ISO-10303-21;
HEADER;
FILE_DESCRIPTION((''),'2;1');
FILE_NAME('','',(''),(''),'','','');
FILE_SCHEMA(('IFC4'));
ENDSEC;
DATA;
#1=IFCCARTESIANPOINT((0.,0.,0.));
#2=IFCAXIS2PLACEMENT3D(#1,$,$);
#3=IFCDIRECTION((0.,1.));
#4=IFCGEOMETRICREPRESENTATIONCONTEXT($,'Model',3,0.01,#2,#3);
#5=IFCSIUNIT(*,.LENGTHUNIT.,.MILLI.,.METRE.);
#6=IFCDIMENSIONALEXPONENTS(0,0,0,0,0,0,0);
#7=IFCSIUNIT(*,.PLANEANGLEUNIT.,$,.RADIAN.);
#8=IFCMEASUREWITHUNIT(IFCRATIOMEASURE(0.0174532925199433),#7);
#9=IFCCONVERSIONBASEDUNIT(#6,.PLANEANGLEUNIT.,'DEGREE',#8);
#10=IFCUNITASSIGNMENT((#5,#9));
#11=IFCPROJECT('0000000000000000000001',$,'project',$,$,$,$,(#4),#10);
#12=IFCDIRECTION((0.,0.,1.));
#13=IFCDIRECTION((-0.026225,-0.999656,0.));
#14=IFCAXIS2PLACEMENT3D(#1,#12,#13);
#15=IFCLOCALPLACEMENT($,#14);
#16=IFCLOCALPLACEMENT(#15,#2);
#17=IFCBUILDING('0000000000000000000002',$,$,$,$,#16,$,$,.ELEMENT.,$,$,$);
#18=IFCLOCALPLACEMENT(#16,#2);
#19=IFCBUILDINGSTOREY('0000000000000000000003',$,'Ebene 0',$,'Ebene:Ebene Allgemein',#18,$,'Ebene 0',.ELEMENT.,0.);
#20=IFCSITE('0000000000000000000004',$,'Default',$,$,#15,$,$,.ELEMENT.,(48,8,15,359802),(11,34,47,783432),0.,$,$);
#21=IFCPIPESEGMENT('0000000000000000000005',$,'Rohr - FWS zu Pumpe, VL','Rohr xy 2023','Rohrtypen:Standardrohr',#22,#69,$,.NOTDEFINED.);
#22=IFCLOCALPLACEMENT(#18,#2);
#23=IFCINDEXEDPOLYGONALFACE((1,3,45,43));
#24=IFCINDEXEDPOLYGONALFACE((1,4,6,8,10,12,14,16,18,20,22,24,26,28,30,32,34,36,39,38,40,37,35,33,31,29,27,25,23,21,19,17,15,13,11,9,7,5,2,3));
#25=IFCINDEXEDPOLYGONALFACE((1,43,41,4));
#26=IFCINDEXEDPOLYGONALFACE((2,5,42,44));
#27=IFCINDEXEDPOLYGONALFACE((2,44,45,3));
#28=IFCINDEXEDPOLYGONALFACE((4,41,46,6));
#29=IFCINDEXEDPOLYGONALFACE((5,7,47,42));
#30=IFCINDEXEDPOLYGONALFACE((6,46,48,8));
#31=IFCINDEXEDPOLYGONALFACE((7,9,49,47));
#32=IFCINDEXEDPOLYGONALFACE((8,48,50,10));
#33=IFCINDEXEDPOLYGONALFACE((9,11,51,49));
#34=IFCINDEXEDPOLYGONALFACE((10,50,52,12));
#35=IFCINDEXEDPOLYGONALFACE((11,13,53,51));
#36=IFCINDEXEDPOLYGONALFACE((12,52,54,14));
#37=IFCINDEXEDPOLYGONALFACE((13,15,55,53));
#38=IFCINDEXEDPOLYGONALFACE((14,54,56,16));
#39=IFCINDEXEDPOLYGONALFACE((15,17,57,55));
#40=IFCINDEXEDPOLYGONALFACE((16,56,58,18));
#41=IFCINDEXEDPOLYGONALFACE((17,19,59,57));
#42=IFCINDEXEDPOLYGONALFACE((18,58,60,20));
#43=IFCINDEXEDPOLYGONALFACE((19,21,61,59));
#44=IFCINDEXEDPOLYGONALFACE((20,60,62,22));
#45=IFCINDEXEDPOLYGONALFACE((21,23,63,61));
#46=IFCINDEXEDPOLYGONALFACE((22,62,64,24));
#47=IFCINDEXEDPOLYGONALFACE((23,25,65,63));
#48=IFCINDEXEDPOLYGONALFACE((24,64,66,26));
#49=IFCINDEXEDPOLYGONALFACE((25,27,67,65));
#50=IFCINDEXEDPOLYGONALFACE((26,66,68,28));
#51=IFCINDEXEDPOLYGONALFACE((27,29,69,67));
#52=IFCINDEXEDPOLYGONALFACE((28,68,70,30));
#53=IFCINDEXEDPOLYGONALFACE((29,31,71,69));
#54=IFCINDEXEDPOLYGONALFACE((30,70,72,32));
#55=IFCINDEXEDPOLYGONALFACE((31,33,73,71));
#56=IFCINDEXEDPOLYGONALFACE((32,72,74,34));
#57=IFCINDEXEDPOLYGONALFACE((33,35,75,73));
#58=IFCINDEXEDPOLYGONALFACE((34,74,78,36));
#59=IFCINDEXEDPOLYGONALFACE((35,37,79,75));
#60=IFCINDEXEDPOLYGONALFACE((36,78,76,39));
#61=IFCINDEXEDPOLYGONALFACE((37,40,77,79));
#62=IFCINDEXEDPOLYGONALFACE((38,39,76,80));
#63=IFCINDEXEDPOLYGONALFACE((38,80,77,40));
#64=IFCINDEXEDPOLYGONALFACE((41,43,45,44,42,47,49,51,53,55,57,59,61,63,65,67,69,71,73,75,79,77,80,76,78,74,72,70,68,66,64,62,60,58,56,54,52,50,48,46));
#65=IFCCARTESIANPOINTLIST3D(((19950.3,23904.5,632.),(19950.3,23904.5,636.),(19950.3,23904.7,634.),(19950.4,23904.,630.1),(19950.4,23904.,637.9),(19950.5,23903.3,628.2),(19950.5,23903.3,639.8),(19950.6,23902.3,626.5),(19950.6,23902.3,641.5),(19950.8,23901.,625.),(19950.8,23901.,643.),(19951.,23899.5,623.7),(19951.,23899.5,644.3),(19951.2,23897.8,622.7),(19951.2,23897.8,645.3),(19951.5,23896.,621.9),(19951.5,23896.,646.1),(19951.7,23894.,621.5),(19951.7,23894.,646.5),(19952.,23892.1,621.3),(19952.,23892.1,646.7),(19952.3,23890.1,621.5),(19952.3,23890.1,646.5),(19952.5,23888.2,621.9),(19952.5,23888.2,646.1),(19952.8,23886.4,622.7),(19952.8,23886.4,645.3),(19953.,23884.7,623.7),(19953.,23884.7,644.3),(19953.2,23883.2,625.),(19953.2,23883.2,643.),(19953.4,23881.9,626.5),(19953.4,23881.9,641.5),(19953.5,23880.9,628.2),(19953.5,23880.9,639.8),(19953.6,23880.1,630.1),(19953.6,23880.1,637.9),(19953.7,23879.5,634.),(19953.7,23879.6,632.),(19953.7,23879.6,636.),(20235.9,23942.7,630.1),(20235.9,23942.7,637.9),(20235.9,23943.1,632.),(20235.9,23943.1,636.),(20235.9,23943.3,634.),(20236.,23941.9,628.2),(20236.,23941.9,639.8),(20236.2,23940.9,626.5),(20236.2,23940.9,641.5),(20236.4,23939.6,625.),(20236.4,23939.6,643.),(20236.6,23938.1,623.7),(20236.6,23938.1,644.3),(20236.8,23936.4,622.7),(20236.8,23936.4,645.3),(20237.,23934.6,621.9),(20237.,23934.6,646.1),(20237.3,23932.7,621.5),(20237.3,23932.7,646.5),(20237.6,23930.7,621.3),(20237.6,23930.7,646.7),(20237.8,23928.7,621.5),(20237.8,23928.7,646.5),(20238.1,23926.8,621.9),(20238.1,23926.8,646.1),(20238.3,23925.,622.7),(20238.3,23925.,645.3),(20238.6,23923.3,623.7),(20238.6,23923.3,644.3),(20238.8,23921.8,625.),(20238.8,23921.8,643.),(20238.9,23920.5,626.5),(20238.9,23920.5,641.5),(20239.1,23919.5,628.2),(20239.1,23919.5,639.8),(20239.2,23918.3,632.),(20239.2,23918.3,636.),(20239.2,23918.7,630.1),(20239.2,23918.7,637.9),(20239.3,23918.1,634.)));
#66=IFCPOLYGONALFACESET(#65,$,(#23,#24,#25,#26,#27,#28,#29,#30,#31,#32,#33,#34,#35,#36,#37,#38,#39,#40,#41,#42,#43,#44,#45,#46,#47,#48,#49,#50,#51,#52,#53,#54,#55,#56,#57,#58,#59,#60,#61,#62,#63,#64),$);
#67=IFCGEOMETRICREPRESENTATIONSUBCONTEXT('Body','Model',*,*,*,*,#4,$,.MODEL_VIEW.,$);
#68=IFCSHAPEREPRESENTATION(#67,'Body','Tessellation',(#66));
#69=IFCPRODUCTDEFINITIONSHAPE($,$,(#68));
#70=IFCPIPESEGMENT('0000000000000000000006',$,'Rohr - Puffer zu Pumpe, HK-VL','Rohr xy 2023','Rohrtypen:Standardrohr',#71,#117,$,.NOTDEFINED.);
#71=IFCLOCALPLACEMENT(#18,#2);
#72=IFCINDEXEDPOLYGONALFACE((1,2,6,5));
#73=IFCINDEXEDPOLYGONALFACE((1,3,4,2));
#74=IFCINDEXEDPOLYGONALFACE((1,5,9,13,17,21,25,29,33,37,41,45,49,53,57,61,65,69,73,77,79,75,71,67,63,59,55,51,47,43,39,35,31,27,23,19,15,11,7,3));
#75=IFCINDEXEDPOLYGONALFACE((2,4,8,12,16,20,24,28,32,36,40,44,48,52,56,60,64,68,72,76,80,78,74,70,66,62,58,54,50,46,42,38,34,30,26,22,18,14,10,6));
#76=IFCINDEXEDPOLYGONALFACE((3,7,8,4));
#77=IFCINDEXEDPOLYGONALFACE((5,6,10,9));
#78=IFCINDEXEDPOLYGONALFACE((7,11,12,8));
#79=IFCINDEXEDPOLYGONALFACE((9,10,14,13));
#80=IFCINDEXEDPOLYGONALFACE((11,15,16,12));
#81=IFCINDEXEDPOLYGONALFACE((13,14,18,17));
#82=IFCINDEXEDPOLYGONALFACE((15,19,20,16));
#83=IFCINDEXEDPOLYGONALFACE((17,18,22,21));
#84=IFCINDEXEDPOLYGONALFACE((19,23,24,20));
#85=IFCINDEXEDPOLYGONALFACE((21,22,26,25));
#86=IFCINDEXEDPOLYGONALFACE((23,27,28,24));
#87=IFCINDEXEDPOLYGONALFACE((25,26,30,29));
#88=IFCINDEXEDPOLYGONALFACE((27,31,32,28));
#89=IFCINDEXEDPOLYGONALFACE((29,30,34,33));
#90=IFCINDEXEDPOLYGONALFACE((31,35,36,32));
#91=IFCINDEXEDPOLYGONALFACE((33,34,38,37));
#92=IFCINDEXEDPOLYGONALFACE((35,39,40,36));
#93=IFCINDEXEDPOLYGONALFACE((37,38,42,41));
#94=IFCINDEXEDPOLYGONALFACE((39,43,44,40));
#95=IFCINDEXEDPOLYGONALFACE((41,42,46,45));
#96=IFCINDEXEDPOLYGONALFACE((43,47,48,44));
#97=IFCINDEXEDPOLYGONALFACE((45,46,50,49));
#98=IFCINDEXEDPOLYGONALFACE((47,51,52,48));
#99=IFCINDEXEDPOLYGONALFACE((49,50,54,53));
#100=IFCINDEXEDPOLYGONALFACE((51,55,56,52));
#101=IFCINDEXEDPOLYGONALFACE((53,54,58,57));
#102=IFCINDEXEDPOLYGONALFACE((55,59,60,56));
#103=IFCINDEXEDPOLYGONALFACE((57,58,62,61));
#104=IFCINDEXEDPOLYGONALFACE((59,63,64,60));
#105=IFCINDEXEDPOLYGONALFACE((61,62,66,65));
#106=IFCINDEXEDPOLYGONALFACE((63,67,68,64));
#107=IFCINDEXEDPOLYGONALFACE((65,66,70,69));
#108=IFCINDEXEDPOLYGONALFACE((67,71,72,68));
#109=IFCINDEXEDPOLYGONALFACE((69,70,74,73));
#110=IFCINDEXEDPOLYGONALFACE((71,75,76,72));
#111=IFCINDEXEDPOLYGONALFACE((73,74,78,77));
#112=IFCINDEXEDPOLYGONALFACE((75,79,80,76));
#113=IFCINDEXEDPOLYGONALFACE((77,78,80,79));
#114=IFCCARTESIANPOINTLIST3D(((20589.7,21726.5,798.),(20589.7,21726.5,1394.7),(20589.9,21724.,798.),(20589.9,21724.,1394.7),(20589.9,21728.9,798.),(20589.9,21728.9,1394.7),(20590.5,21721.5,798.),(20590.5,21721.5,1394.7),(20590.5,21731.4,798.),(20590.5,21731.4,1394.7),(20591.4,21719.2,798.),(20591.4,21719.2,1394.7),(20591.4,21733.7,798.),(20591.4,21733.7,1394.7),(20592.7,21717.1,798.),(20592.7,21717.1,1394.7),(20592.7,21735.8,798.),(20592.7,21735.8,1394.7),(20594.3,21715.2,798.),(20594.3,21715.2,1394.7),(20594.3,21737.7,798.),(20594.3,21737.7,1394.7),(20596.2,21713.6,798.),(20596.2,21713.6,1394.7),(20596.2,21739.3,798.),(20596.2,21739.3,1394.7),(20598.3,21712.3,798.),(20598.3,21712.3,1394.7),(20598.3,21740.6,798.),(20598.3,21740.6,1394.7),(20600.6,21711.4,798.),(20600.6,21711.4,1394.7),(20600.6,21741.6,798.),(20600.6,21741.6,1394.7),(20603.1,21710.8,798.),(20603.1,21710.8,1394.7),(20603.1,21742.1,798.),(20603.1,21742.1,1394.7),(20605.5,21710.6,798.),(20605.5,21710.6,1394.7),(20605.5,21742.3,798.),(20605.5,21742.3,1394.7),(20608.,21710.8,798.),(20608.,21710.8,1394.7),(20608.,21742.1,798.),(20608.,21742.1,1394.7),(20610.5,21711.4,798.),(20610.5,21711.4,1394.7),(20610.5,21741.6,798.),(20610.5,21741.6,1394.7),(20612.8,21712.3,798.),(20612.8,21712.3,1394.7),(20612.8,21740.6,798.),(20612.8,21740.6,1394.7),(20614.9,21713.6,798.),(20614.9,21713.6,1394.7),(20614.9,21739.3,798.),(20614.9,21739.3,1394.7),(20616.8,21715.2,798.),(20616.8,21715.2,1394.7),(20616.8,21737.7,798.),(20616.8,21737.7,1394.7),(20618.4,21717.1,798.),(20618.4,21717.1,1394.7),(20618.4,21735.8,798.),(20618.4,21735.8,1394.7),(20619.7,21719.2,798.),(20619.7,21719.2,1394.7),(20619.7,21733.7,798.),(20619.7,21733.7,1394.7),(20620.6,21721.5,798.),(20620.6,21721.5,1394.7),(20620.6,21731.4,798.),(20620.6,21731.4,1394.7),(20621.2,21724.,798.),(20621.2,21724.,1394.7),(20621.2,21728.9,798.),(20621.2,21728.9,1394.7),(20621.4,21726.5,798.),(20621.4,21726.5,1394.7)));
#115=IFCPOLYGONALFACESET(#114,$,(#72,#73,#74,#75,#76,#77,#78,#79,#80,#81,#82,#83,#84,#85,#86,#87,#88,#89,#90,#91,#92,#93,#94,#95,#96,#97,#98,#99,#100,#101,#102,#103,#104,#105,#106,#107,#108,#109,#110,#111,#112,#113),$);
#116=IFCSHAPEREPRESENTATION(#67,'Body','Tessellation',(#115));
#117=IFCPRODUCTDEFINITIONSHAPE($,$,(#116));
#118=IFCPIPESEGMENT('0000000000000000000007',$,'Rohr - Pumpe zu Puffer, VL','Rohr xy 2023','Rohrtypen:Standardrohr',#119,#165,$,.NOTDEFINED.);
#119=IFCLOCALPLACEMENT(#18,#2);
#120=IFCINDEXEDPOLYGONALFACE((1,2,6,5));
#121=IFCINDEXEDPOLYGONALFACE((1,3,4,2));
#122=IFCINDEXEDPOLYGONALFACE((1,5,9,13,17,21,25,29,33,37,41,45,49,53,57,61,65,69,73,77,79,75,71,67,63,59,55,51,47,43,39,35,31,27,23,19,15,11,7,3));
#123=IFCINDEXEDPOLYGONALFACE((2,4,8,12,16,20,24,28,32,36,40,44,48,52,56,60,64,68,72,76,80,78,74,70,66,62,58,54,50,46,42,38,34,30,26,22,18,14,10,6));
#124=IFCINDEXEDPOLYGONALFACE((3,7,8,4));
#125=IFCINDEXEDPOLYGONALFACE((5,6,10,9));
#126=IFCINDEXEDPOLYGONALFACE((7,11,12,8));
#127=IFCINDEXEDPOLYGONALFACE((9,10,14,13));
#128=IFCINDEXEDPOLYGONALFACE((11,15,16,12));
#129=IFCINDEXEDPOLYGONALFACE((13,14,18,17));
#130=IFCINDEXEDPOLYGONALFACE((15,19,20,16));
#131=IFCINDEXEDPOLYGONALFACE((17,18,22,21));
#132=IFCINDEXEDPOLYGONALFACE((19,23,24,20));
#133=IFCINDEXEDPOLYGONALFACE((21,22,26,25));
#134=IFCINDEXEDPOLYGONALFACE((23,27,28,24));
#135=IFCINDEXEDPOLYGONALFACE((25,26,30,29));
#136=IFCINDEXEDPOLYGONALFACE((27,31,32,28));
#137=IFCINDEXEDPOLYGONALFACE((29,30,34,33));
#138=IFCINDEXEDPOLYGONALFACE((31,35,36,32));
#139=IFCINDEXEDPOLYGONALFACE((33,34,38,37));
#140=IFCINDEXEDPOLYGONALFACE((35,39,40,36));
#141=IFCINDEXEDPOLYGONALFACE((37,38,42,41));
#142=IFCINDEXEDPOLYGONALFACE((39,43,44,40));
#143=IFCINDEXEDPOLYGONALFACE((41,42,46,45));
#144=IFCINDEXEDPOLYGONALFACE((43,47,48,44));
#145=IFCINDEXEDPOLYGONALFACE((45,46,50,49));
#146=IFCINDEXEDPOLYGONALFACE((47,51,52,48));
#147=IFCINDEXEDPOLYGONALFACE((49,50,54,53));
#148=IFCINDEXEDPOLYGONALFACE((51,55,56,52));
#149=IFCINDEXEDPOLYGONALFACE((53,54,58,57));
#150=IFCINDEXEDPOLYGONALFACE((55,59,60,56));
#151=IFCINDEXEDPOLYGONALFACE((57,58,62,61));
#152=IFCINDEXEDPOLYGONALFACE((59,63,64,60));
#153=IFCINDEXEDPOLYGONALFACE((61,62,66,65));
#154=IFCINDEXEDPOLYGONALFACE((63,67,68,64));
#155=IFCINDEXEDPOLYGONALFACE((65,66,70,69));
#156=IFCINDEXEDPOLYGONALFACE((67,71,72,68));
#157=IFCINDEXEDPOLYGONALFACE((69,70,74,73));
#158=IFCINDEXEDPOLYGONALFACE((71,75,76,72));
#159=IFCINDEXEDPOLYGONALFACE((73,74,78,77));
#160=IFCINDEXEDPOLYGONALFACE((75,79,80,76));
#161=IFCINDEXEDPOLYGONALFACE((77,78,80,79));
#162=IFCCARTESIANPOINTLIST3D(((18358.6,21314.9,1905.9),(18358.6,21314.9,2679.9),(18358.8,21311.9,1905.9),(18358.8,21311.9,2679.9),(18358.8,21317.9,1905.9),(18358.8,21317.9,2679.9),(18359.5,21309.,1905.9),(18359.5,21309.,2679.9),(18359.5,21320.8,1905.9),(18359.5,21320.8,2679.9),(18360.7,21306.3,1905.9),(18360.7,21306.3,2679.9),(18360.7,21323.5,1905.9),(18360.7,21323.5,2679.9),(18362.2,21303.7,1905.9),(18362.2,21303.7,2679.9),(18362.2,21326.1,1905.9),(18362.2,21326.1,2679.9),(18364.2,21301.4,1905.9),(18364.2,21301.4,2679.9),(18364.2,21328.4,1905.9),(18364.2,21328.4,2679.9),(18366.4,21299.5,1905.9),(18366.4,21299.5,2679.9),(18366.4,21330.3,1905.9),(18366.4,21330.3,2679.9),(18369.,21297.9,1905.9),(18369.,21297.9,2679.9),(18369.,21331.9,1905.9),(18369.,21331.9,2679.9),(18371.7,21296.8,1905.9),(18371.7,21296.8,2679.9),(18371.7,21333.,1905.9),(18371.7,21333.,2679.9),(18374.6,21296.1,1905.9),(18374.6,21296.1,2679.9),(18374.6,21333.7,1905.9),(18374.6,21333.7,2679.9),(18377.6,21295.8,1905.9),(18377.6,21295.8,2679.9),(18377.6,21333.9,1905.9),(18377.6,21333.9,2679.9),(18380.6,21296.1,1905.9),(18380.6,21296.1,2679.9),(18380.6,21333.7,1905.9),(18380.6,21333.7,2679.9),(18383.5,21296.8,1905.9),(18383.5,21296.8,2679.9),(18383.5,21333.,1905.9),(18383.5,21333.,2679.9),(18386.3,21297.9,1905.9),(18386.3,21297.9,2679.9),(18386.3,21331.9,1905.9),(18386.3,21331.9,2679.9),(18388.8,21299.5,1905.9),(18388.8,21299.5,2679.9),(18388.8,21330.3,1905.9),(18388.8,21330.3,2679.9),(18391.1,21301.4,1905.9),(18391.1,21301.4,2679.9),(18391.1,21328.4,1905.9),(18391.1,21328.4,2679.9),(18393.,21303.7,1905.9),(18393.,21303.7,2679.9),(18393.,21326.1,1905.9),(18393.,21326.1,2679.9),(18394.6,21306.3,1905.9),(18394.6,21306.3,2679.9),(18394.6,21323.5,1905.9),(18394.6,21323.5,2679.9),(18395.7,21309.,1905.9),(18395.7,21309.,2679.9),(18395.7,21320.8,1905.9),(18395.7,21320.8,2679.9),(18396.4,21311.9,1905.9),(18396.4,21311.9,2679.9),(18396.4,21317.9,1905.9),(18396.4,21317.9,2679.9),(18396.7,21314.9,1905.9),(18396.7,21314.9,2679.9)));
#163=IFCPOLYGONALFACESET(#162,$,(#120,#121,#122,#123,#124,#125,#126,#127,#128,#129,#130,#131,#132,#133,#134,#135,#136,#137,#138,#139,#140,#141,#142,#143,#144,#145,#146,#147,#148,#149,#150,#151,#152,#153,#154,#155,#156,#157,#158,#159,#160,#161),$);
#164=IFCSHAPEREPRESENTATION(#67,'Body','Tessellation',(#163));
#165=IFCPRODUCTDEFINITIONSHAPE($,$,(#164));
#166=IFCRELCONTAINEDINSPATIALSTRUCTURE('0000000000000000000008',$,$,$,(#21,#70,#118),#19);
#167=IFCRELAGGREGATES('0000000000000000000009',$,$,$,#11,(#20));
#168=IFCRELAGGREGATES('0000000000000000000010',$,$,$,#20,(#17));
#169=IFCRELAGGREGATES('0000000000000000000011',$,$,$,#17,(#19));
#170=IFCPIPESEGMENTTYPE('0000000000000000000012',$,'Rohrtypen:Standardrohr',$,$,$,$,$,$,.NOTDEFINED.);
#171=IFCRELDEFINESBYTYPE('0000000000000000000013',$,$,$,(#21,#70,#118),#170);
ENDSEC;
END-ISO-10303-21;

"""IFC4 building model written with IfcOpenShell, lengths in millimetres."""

from ifc_helpers import new_model, entity, si_unit, converted_unit, direction, frame, origin, place, context, subcontext, project, spatial, indexed_curve, outline, extrude, type_object, element, save


model = new_model("IFC4")

# Units and contexts
model_context = context("Model", 3, precision=0.01, world=origin(), true_north=direction((0.0, 1.0)))
body_context = subcontext(model_context, "Body", "Model", "MODEL_VIEW")
ifc_project = project(units=[si_unit("LENGTHUNIT", "METRE", prefix="MILLI"), converted_unit("PLANEANGLEUNIT", "DEGREE", entity("IfcRatioMeasure", 0.0174532925199433), si_unit("PLANEANGLEUNIT", "RADIAN"), dimensions=[0, 0, 0, 0, 0, 0, 0])], contexts=[model_context])

# Site, building, storey
site_placement = place(None, frame((0.0, 0.0, 0.0), z_axis=(0.0, 0.0, 1.0), x_axis=(-0.026225, -0.999656, 0.0)))
site = spatial("IfcSite", under=ifc_project, at=site_placement, Name="Default", CompositionType="ELEMENT", RefLatitude=(48, 8, 15, 359802), RefLongitude=(11, 34, 47, 783432), RefElevation=0.0)
building_placement = place(site_placement, origin())
building = spatial("IfcBuilding", under=site, at=building_placement, CompositionType="ELEMENT")
storey_placement = place(building_placement, origin())
storey = spatial("IfcBuildingStorey", under=building, at=storey_placement, Name="Ebene 0", ObjectType="Ebene:Ebene Allgemein", LongName="Ebene 0", CompositionType="ELEMENT", Elevation=0.0)

# Pipe segments
pipe_segment_type = type_object("IfcPipeSegmentType", Name="Rohrtypen:Standardrohr", PredefinedType="NOTDEFINED")
pipe_segment_1_placement = place(storey_placement, origin())
element("IfcPipeSegment", 1, at=pipe_segment_1_placement, inside=storey, type_object=pipe_segment_type, Name="Rohr - FWS zu Pumpe, VL", Description="Rohr xy 2023", ObjectType="Rohrtypen:Standardrohr", PredefinedType="NOTDEFINED", context=body_context, shape_type="SweptSolid", body=[
    extrude(outline(indexed_curve([(12.7, 0.0), (12.5, 2.0), (12.1, 3.9), (11.3, 5.8), (10.3, 7.5), (9.0, 9.0), (7.5, 10.3), (5.8, 11.3), (3.9, 12.1), (2.0, 12.5), (0.0, 12.7), (-2.0, 12.5), (-3.9, 12.1), (-5.8, 11.3), (-7.5, 10.3), (-9.0, 9.0), (-10.3, 7.5), (-11.3, 5.8), (-12.1, 3.9), (-12.5, 2.0), (-12.7, 0.0), (-12.5, -2.0), (-12.1, -3.9), (-11.3, -5.8), (-10.3, -7.5), (-9.0, -9.0), (-7.5, -10.3), (-5.8, -11.3), (-3.9, -12.1), (-2.0, -12.5), (0.0, -12.7), (2.0, -12.5), (3.9, -12.1), (5.8, -11.3), (7.5, -10.3), (9.0, -9.0), (10.3, -7.5), (11.3, -5.8), (12.1, -3.9), (12.5, -2.0), (12.7, 0.0)], self_intersect=False)), frame((19952.0, 23892.1, 634.0), z_axis=(0.990977, 0.134035, 0.0), x_axis=(0.134035, -0.990977, 0.0)), (0.0, 0.0, 1.0), 288.2),
])
pipe_segment_2_placement = place(storey_placement, origin())
element("IfcPipeSegment", 2, at=pipe_segment_2_placement, inside=storey, type_object=pipe_segment_type, Name="Rohr - Puffer zu Pumpe, HK-VL", Description="Rohr xy 2023", ObjectType="Rohrtypen:Standardrohr", PredefinedType="NOTDEFINED", context=body_context, shape_type="SweptSolid", body=[
    extrude(outline(indexed_curve([(15.9, 0.0), (15.7, 2.5), (15.1, 4.9), (14.1, 7.2), (12.8, 9.3), (11.2, 11.2), (9.3, 12.8), (7.2, 14.1), (4.9, 15.1), (2.5, 15.7), (0.0, 15.9), (-2.5, 15.7), (-4.9, 15.1), (-7.2, 14.1), (-9.3, 12.8), (-11.2, 11.2), (-12.8, 9.3), (-14.1, 7.2), (-15.1, 4.9), (-15.7, 2.5), (-15.9, 0.0), (-15.7, -2.5), (-15.1, -4.9), (-14.1, -7.2), (-12.8, -9.3), (-11.2, -11.2), (-9.3, -12.8), (-7.2, -14.1), (-4.9, -15.1), (-2.5, -15.7), (0.0, -15.9), (2.5, -15.7), (4.9, -15.1), (7.2, -14.1), (9.3, -12.8), (11.2, -11.2), (12.8, -9.3), (14.1, -7.2), (15.1, -4.9), (15.7, -2.5), (15.9, 0.0)], self_intersect=False)), frame((20605.5, 21726.5, 798.0), z_axis=(0.0, 0.0, 1.0), x_axis=(-1.0, 0.0, 0.0)), (0.0, 0.0, 1.0), 596.7),
])
pipe_segment_3_placement = place(storey_placement, origin())
element("IfcPipeSegment", 3, at=pipe_segment_3_placement, inside=storey, type_object=pipe_segment_type, Name="Rohr - Pumpe zu Puffer, VL", Description="Rohr xy 2023", ObjectType="Rohrtypen:Standardrohr", PredefinedType="NOTDEFINED", context=body_context, shape_type="SweptSolid", body=[
    extrude(outline(indexed_curve([(19.1, 0.0), (18.8, 3.0), (18.1, 5.9), (17.0, 8.6), (15.4, 11.2), (13.5, 13.5), (11.2, 15.4), (8.6, 17.0), (5.9, 18.1), (3.0, 18.8), (0.0, 19.1), (-3.0, 18.8), (-5.9, 18.1), (-8.6, 17.0), (-11.2, 15.4), (-13.5, 13.5), (-15.4, 11.2), (-17.0, 8.6), (-18.1, 5.9), (-18.8, 3.0), (-19.1, 0.0), (-18.8, -3.0), (-18.1, -5.9), (-17.0, -8.6), (-15.4, -11.2), (-13.5, -13.5), (-11.2, -15.4), (-8.6, -17.0), (-5.9, -18.1), (-3.0, -18.8), (0.0, -19.1), (3.0, -18.8), (5.9, -18.1), (8.6, -17.0), (11.2, -15.4), (13.5, -13.5), (15.4, -11.2), (17.0, -8.6), (18.1, -5.9), (18.8, -3.0), (19.1, 0.0)], self_intersect=False)), frame((18377.6, 21314.9, 1905.9), z_axis=(0.0, 0.0, 1.0), x_axis=(-1.0, 0.0, 0.0)), (0.0, 0.0, 1.0), 774.0),
])

save(model, "model.ifc")
